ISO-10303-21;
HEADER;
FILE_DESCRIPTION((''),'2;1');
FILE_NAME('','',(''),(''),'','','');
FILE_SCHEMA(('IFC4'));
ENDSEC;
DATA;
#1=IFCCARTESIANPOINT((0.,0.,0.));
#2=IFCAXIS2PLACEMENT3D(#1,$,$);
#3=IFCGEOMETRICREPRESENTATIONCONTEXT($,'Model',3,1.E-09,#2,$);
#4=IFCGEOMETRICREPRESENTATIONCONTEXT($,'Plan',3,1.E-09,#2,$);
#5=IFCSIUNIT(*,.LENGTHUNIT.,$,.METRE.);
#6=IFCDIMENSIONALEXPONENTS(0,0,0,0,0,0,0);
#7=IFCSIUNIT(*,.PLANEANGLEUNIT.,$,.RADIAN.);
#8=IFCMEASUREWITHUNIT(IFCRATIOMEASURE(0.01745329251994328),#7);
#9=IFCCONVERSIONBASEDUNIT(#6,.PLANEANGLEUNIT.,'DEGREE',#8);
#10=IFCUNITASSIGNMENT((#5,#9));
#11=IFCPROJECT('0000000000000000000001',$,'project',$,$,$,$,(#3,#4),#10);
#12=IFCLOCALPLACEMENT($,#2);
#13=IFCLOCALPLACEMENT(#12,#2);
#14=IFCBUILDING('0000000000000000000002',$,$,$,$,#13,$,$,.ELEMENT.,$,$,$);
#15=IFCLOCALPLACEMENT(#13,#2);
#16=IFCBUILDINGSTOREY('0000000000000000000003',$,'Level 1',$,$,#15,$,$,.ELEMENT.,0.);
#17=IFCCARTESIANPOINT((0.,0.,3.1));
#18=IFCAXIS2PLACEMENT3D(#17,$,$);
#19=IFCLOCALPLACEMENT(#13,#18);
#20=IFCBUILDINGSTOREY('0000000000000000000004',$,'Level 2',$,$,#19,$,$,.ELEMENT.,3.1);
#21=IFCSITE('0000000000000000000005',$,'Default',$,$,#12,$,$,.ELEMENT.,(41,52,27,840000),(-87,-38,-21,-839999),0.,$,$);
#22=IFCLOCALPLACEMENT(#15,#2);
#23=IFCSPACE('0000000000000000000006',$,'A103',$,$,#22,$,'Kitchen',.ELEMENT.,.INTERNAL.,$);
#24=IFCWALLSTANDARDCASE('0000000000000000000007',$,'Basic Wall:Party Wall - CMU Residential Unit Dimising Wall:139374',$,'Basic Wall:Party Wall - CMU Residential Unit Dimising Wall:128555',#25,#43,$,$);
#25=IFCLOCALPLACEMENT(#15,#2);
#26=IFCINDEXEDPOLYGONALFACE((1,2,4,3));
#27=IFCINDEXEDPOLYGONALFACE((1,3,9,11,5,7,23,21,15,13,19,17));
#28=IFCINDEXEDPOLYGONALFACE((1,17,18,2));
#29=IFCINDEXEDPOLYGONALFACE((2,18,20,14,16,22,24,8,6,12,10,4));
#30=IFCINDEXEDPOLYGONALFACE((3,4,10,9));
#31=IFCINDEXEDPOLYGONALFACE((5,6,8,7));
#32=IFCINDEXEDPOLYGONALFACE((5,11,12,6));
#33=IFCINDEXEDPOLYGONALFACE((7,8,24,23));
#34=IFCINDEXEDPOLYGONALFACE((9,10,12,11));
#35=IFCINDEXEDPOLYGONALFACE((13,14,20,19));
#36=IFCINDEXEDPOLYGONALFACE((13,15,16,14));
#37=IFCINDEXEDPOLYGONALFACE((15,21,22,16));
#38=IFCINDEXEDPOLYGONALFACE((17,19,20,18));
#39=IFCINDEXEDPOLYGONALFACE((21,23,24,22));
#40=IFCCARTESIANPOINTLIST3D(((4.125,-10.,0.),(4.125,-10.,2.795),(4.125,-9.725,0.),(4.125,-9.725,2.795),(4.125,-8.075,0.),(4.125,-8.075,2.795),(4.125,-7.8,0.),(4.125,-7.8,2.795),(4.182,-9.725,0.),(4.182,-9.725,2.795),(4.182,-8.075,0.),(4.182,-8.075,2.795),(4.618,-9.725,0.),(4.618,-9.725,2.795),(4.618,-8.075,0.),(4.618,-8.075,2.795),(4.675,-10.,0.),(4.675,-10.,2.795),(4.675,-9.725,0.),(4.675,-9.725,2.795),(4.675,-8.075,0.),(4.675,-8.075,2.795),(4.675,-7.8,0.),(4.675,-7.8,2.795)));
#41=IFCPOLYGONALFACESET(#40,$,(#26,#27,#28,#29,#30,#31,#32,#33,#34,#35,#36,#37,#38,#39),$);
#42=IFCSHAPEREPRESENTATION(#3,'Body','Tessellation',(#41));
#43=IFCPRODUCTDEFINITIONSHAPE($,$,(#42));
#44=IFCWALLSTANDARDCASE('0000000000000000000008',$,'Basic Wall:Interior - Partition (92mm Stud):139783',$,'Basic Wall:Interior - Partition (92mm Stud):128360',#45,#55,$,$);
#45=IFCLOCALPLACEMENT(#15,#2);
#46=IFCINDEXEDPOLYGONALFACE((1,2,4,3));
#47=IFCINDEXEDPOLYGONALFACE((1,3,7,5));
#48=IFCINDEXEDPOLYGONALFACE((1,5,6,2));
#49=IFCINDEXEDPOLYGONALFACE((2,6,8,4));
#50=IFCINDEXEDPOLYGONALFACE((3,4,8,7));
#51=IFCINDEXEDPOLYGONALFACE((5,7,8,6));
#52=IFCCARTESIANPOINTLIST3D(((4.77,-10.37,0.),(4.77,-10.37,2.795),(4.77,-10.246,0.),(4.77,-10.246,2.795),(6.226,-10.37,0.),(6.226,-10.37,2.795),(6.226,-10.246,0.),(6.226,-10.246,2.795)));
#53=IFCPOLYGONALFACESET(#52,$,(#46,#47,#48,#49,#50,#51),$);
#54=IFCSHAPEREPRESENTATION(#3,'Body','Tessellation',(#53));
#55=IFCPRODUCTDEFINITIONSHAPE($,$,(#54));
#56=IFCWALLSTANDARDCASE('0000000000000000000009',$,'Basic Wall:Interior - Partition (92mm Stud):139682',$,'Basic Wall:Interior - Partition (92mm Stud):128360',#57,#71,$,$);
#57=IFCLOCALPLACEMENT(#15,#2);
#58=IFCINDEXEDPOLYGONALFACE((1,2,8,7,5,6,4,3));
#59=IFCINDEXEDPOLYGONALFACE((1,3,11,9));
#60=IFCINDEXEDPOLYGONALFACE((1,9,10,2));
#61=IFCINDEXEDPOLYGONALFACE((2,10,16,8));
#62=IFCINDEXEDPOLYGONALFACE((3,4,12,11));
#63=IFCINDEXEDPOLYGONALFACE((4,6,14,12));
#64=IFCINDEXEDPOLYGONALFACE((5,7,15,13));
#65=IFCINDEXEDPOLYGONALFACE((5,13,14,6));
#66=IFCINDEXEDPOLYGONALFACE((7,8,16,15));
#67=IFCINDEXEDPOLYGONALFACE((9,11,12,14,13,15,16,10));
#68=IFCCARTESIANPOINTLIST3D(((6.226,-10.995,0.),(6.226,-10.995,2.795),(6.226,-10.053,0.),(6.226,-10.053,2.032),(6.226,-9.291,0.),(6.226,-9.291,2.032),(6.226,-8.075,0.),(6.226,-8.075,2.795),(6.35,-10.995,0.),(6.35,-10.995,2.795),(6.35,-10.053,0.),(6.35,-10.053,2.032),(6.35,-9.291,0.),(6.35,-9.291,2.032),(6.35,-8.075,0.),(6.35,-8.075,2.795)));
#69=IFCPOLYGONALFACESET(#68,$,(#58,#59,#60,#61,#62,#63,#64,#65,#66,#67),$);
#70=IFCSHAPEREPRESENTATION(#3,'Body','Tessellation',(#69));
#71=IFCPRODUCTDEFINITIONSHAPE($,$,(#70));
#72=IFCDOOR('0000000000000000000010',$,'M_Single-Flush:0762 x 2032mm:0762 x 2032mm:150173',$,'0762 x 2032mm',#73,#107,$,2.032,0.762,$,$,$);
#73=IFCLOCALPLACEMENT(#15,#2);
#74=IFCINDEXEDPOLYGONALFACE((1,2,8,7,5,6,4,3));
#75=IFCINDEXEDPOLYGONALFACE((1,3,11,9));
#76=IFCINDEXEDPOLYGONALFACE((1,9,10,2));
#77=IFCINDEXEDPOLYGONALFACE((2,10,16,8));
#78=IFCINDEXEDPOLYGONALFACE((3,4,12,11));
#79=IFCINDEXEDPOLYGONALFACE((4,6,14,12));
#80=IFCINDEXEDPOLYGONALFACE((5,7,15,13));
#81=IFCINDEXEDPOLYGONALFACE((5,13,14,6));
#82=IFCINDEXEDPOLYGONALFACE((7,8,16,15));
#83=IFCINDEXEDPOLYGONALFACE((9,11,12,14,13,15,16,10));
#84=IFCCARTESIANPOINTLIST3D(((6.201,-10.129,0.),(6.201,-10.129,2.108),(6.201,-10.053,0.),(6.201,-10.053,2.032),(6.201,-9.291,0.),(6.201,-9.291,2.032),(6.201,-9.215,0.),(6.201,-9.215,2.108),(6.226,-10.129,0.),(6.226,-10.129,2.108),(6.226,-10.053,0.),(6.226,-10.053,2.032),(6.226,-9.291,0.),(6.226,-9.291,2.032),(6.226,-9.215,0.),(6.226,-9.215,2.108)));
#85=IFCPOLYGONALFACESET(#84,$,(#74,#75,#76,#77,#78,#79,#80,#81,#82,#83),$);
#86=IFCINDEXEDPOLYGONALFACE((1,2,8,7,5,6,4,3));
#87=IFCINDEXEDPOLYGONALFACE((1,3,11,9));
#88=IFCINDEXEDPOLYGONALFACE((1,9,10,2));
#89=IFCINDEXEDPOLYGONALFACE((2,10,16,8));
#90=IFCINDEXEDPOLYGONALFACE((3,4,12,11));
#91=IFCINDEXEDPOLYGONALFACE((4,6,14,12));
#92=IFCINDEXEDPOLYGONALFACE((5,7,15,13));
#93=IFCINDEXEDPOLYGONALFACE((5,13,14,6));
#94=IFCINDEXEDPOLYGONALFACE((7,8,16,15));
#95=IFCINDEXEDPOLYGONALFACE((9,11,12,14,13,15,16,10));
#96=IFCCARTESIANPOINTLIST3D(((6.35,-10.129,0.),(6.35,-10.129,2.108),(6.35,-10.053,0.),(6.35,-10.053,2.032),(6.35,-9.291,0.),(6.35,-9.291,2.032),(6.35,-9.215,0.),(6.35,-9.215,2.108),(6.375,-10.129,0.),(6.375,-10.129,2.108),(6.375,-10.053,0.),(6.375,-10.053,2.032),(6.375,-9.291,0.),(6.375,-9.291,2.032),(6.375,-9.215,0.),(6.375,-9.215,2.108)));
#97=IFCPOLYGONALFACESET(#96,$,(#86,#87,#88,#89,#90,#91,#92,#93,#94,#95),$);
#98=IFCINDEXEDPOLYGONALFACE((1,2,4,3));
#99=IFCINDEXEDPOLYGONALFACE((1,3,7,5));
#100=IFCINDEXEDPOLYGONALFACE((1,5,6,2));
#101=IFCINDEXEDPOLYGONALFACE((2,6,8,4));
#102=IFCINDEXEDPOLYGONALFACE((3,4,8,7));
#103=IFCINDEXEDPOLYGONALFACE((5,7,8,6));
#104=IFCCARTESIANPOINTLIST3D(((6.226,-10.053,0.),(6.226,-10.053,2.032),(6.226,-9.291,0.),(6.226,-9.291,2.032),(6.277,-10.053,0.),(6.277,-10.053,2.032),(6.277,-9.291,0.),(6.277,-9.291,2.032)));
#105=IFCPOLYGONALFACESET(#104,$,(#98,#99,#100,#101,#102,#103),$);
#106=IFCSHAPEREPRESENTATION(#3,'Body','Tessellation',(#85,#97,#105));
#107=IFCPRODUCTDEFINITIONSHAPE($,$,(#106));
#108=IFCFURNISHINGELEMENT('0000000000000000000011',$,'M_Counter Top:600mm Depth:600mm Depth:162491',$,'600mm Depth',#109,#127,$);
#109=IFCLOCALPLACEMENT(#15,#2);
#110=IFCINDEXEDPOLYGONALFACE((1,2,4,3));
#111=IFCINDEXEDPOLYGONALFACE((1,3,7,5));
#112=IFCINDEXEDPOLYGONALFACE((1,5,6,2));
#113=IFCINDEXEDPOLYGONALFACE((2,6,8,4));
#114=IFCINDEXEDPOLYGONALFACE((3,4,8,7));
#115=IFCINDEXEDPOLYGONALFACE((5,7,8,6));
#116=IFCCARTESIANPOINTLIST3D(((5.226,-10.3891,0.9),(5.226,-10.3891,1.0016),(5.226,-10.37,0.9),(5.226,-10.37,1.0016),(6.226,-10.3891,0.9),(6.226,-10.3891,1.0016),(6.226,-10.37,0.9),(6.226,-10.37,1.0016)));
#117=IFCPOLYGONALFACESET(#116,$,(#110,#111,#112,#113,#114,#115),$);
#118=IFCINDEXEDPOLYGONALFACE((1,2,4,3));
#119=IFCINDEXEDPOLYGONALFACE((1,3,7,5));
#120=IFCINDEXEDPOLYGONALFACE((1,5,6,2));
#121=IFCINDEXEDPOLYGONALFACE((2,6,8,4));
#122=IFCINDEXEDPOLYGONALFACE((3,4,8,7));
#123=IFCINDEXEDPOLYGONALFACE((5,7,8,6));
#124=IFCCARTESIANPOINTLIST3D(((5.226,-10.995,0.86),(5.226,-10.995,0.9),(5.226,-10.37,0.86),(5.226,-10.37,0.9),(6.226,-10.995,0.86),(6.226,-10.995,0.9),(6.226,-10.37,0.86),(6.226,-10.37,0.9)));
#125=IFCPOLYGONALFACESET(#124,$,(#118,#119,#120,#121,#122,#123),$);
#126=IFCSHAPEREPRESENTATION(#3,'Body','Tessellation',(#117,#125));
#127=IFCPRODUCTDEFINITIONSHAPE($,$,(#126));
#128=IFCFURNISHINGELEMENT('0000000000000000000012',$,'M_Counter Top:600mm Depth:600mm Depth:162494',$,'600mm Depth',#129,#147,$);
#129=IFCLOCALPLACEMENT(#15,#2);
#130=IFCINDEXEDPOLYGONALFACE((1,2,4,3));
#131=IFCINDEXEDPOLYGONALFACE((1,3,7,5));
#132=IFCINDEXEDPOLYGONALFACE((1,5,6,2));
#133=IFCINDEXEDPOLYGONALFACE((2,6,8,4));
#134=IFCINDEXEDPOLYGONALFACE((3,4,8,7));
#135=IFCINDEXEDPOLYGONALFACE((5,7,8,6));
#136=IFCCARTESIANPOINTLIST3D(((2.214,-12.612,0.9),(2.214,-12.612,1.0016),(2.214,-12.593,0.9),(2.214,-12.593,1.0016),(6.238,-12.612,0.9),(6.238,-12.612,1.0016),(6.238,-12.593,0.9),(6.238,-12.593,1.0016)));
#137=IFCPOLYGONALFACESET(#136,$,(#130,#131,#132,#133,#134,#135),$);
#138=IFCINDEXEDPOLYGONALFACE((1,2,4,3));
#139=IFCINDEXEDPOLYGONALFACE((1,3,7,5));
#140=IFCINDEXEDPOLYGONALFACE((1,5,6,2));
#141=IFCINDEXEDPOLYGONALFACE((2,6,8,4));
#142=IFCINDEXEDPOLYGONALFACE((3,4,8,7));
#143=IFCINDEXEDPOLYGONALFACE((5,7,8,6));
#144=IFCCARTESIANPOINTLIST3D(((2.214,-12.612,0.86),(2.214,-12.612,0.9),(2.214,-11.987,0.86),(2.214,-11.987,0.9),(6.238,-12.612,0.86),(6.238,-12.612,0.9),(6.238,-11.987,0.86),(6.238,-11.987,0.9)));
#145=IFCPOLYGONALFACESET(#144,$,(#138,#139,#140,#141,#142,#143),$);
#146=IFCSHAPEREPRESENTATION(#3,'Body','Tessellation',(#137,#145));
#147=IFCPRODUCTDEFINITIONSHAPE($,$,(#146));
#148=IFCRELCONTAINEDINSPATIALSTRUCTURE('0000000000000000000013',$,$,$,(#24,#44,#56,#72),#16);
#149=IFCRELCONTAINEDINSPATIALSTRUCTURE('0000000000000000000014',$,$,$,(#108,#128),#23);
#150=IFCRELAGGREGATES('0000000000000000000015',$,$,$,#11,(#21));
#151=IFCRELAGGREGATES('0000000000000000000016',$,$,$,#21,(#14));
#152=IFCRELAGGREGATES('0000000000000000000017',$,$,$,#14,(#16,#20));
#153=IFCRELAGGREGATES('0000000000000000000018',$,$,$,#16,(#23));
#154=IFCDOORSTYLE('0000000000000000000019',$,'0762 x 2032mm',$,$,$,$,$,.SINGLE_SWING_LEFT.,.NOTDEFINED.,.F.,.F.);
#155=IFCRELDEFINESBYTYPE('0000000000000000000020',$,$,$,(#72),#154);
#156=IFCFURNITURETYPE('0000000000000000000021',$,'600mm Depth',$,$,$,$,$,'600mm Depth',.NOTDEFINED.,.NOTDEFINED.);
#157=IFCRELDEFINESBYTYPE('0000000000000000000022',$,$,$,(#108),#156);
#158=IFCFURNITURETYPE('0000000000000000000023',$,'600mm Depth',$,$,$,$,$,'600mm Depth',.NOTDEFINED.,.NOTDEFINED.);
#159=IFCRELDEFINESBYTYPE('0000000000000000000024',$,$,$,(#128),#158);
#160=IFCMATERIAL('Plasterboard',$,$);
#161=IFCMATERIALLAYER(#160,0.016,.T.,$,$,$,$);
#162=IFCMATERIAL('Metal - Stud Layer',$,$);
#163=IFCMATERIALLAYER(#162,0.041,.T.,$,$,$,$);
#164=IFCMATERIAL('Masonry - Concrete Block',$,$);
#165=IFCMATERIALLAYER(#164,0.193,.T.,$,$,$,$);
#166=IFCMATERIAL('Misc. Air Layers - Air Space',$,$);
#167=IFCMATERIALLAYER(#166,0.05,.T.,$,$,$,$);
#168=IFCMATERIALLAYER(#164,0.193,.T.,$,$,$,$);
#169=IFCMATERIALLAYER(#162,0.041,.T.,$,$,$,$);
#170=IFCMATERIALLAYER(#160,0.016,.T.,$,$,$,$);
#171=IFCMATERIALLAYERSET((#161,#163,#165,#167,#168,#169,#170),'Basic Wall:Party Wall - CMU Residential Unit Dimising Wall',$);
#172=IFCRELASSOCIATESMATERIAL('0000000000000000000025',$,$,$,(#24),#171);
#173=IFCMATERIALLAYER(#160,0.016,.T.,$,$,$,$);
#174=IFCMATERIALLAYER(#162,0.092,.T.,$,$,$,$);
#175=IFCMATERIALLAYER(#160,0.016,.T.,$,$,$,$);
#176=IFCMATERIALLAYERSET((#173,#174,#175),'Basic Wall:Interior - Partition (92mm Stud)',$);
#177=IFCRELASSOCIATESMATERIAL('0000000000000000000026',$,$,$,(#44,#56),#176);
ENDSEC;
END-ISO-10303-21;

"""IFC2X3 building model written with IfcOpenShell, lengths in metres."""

from ifc_helpers import new_model, entity, si_unit, converted_unit, frame, frame_2d, origin, origin_2d_with_axis, place, context, project, spatial, polyline, rectangle, outline, extrude, clip, bounded_halfspace, source, transform, mapped, material, layer, layer_set, layer_usage, type_object, type_shapes, element, fill, save


model = new_model("IFC2X3")

# Units and contexts
model_context = context("Model", 3, precision=1e-09, world=origin())
plan_context = context("Plan", 3, precision=1e-09, world=origin())
ifc_project = project(units=[si_unit("LENGTHUNIT", "METRE"), converted_unit("PLANEANGLEUNIT", "DEGREE", entity("IfcRatioMeasure", 0.01745329251994328), si_unit("PLANEANGLEUNIT", "RADIAN"), dimensions=[0, 0, 0, 0, 0, 0, 0])], contexts=[model_context, plan_context])

# Site, building, storey
site_placement = place(None, origin())
site = spatial("IfcSite", under=ifc_project, at=site_placement, Name="Default", CompositionType="ELEMENT", RefLatitude=(41, 52, 27, 840000), RefLongitude=(-87, -38, -21, -839999), RefElevation=0.0)
building_placement = place(site_placement, origin())
building = spatial("IfcBuilding", under=site, at=building_placement, CompositionType="ELEMENT")
storey_1_placement = place(building_placement, origin())
storey_1 = spatial("IfcBuildingStorey", under=building, at=storey_1_placement, Name="Level 1", CompositionType="ELEMENT", Elevation=0.0)

# Shared definitions
ifc_material_1 = material(Name="Misc. Air Layers - Air Space")
ifc_material_2 = material(Name="Masonry - Concrete Block")
ifc_material_3 = material(Name="Metal - Stud Layer")
ifc_material_4 = material(Name="Plasterboard")

# Shared definitions
ifc_layer_1 = layer(ifc_material_4, 0.016, ventilated=True)
ifc_layer_2 = layer(ifc_material_3, 0.041, ventilated=True)
ifc_layer_3 = layer(ifc_material_2, 0.193, ventilated=True)
ifc_layer_4 = layer(ifc_material_1, 0.05, ventilated=True)
ifc_layer_5 = layer(ifc_material_2, 0.193, ventilated=True)
ifc_layer_6 = layer(ifc_material_3, 0.041, ventilated=True)
ifc_layer_7 = layer(ifc_material_4, 0.016, ventilated=True)
ifc_layer_set_1 = layer_set([ifc_layer_1, ifc_layer_2, ifc_layer_3, ifc_layer_4, ifc_layer_5, ifc_layer_6, ifc_layer_7], Name="Basic Wall:Party Wall - CMU Residential Unit Dimising Wall")
ifc_layer_usage_1 = layer_usage(ifc_layer_set_1, "AXIS2", "NEGATIVE", 0.275)
ifc_layer_8 = layer(ifc_material_4, 0.016, ventilated=True)
ifc_layer_9 = layer(ifc_material_3, 0.092, ventilated=True)
ifc_layer_10 = layer(ifc_material_4, 0.016, ventilated=True)
ifc_layer_set_2 = layer_set([ifc_layer_8, ifc_layer_9, ifc_layer_10], Name="Basic Wall:Interior - Partition (92mm Stud)")
ifc_layer_usage_2 = layer_usage(ifc_layer_set_2, "AXIS2", "NEGATIVE", 0.062)

# Shared definitions
storey_2_placement = place(building_placement, frame((0.0, 0.0, 3.1)))
storey_2 = spatial("IfcBuildingStorey", under=building, at=storey_2_placement, Name="Level 2", CompositionType="ELEMENT", Elevation=3.1)

# Walls
wall_1_placement = place(storey_1_placement, frame((4.4, -10.0, 0.0), z_axis=(0.0, 0.0, 1.0), x_axis=(0.0, 1.0, 0.0)))
element("IfcWallStandardCase", 1, at=wall_1_placement, inside=storey_1, material=ifc_layer_usage_1, Name="Basic Wall:Party Wall - CMU Residential Unit Dimising Wall:139374", ObjectType="Basic Wall:Party Wall - CMU Residential Unit Dimising Wall:128555", context=model_context, shape_type="Clipping", body=[
    clip(clip(extrude(rectangle(XDim=2.2, YDim=0.55, at=frame_2d((1.1, 0.0), x_axis=(-1.0, 0.0))), origin(), (0.0, 0.0, 1.0), 2.795), bounded_halfspace(frame((1.925, 0.218, 0.0), z_axis=(0.0, -1.0, 0.0), x_axis=(1.0, 0.0, 0.0)), True, frame((1.925, 0.218, 0.0), z_axis=(0.0, -1.0, 0.0), x_axis=(1.0, 0.0, 0.0)), polyline([(0.0, 0.0), (0.0, 2.795), (-1.65, 2.795), (-1.65, 0.0), (0.0, 0.0)]))), bounded_halfspace(frame((0.275, -0.218, 0.0), z_axis=(0.0, 1.0, 0.0), x_axis=(-1.0, 0.0, 0.0)), True, frame((0.275, -0.218, 0.0), z_axis=(0.0, 1.0, 0.0), x_axis=(-1.0, 0.0, 0.0)), polyline([(0.0, 0.0), (0.0, 2.795), (-1.65, 2.795), (-1.65, 0.0), (0.0, 0.0)]))),
])
wall_2_placement = place(storey_1_placement, frame((4.77, -10.308, 0.0)))
element("IfcWallStandardCase", 2, at=wall_2_placement, inside=storey_1, material=ifc_layer_usage_2, Name="Basic Wall:Interior - Partition (92mm Stud):139783", ObjectType="Basic Wall:Interior - Partition (92mm Stud):128360", context=model_context, shape_type="SweptSolid", body=[
    extrude(rectangle(XDim=1.456, YDim=0.124, at=frame_2d((0.728, 0.0), x_axis=(-1.0, 0.0))), origin(), (0.0, 0.0, 1.0), 2.795),
])

# Wall, opening, door
wall_3_placement = place(storey_1_placement, frame((6.288, -10.995, 0.0), z_axis=(0.0, 0.0, 1.0), x_axis=(0.0, 1.0, 0.0)))
wall_3 = element("IfcWallStandardCase", 3, at=wall_3_placement, inside=storey_1, material=ifc_layer_usage_2, Name="Basic Wall:Interior - Partition (92mm Stud):139682", ObjectType="Basic Wall:Interior - Partition (92mm Stud):128360", context=model_context, shape_type="SweptSolid", body=[
    extrude(rectangle(XDim=2.92, YDim=0.124, at=frame_2d((1.46, 0.0), x_axis=(-1.0, 0.0))), origin(), (0.0, 0.0, 1.0), 2.795),
])
opening_1_placement = place(wall_3_placement, frame((0.942, -0.062, 0.0)))
opening_1 = element("IfcOpeningElement", 4, at=opening_1_placement, cuts=wall_3, ObjectType="Opening", context=model_context, shape_type="SweptSolid", body=[
    extrude(rectangle(XDim=0.762, YDim=2.032, at=frame_2d((1.016, 0.381), x_axis=(0.0, -1.0))), frame((0.0, 0.0, 0.0), z_axis=(0.0, 1.0, 0.0), x_axis=(0.0, 0.0, 1.0)), (0.0, 0.0, 1.0), 0.124),
])
door_style_1 = type_object("IfcDoorStyle", Name="0762 x 2032mm", ConstructionType="NOTDEFINED", OperationType="SINGLE_SWING_LEFT", ParameterTakesPrecedence=False, Sizeable=False)
shared_shape_1 = source(origin(), model_context, "Body", "SweptSolid", [
    extrude(outline(polyline([(-0.457, -1.073), (0.457, -1.073), (0.457, 1.035), (0.381, 1.035), (0.381, -0.997), (-0.381, -0.997), (-0.381, 1.035), (-0.457, 1.035), (-0.457, -1.073)])), frame((0.381, 0.149, 1.035), z_axis=(0.0, -1.0, 0.0), x_axis=(-1.0, 0.0, 0.0)), (0.0, 0.0, 1.0), 0.025),
    extrude(outline(polyline([(-1.073, -0.457), (1.035, -0.457), (1.035, -0.381), (-0.997, -0.381), (-0.997, 0.381), (1.035, 0.381), (1.035, 0.457), (-1.073, 0.457), (-1.073, -0.457)])), frame((0.381, 0.0, 1.035), z_axis=(0.0, -1.0, 0.0), x_axis=(0.0, 0.0, -1.0)), (0.0, 0.0, 1.0), 0.025),
    extrude(rectangle(XDim=0.762, YDim=0.051, at=origin_2d_with_axis()), frame((0.381, 0.0985, 0.0)), (0.0, 0.0, 1.0), 2.032),
])
type_shapes(door_style_1, [shared_shape_1])
door_1_placement = place(opening_1_placement, origin())
door_1 = element("IfcDoor", 5, at=door_1_placement, inside=storey_1, type_object=door_style_1, Name="M_Single-Flush:0762 x 2032mm:0762 x 2032mm:150173", ObjectType="0762 x 2032mm", OverallHeight=2.032, OverallWidth=0.762, context=model_context, shape_type="MappedRepresentation", body=[
    mapped(shared_shape_1, transform((0.0, 0.0, 0.0), scale=1.0)),
])
fill(opening_1, door_1)

# Shared definitions
space_1_placement = place(storey_1_placement, origin())
space_1 = spatial("IfcSpace", under=storey_1, at=space_1_placement, Name="A103", LongName="Kitchen", CompositionType="ELEMENT", InteriorOrExteriorSpace="INTERNAL")

# Furnishing element
furniture_type_1 = type_object("IfcFurnitureType", Name="600mm Depth", ElementType="600mm Depth", AssemblyPlace="NOTDEFINED")
shared_shape_2 = source(origin(), model_context, "Body", "SweptSolid", [
    extrude(rectangle(XDim=0.0191, YDim=1.0, at=origin_2d_with_axis()), frame((-0.7005, -0.0095, 0.9), z_axis=(0.0, 0.0, 1.0), x_axis=(0.0, -1.0, 0.0)), (0.0, 0.0, 1.0), 0.1016),
    extrude(rectangle(XDim=1.0, YDim=0.625, at=origin_2d_with_axis()), frame((-0.7005, -0.3125, 0.86), z_axis=(0.0, 0.0, 1.0), x_axis=(-1.0, 0.0, 0.0)), (0.0, 0.0, 1.0), 0.04),
])
type_shapes(furniture_type_1, [shared_shape_2])
furnishing_1_placement = place(space_1_placement, frame((6.4265, -10.37, 0.0)))
element("IfcFurnishingElement", 6, at=furnishing_1_placement, inside=space_1, type_object=furniture_type_1, Name="M_Counter Top:600mm Depth:600mm Depth:162491", ObjectType="600mm Depth", context=model_context, shape_type="MappedRepresentation", body=[
    mapped(shared_shape_2, transform((0.0, 0.0, 0.0), scale=1.0)),
])

# Furnishing element
furniture_type_2 = type_object("IfcFurnitureType", Name="600mm Depth", ElementType="600mm Depth", AssemblyPlace="NOTDEFINED")
shared_shape_3 = source(origin(), model_context, "Body", "SweptSolid", [
    extrude(rectangle(XDim=0.0191, YDim=4.024, at=origin_2d_with_axis()), frame((0.8115, -0.0095, 0.9), z_axis=(0.0, 0.0, 1.0), x_axis=(0.0, -1.0, 0.0)), (0.0, 0.0, 1.0), 0.1016),
    extrude(rectangle(XDim=4.024, YDim=0.625, at=origin_2d_with_axis()), frame((0.8115, -0.3125, 0.86), z_axis=(0.0, 0.0, 1.0), x_axis=(-1.0, 0.0, 0.0)), (0.0, 0.0, 1.0), 0.04),
])
type_shapes(furniture_type_2, [shared_shape_3])
furnishing_2_placement = place(space_1_placement, frame((5.0375, -12.612, 0.0), z_axis=(0.0, 0.0, 1.0), x_axis=(-1.0, 0.0, 0.0)))
element("IfcFurnishingElement", 7, at=furnishing_2_placement, inside=space_1, type_object=furniture_type_2, Name="M_Counter Top:600mm Depth:600mm Depth:162494", ObjectType="600mm Depth", context=model_context, shape_type="MappedRepresentation", body=[
    mapped(shared_shape_3, transform((0.0, 0.0, 0.0), scale=1.0)),
])

save(model, "model.ifc")
